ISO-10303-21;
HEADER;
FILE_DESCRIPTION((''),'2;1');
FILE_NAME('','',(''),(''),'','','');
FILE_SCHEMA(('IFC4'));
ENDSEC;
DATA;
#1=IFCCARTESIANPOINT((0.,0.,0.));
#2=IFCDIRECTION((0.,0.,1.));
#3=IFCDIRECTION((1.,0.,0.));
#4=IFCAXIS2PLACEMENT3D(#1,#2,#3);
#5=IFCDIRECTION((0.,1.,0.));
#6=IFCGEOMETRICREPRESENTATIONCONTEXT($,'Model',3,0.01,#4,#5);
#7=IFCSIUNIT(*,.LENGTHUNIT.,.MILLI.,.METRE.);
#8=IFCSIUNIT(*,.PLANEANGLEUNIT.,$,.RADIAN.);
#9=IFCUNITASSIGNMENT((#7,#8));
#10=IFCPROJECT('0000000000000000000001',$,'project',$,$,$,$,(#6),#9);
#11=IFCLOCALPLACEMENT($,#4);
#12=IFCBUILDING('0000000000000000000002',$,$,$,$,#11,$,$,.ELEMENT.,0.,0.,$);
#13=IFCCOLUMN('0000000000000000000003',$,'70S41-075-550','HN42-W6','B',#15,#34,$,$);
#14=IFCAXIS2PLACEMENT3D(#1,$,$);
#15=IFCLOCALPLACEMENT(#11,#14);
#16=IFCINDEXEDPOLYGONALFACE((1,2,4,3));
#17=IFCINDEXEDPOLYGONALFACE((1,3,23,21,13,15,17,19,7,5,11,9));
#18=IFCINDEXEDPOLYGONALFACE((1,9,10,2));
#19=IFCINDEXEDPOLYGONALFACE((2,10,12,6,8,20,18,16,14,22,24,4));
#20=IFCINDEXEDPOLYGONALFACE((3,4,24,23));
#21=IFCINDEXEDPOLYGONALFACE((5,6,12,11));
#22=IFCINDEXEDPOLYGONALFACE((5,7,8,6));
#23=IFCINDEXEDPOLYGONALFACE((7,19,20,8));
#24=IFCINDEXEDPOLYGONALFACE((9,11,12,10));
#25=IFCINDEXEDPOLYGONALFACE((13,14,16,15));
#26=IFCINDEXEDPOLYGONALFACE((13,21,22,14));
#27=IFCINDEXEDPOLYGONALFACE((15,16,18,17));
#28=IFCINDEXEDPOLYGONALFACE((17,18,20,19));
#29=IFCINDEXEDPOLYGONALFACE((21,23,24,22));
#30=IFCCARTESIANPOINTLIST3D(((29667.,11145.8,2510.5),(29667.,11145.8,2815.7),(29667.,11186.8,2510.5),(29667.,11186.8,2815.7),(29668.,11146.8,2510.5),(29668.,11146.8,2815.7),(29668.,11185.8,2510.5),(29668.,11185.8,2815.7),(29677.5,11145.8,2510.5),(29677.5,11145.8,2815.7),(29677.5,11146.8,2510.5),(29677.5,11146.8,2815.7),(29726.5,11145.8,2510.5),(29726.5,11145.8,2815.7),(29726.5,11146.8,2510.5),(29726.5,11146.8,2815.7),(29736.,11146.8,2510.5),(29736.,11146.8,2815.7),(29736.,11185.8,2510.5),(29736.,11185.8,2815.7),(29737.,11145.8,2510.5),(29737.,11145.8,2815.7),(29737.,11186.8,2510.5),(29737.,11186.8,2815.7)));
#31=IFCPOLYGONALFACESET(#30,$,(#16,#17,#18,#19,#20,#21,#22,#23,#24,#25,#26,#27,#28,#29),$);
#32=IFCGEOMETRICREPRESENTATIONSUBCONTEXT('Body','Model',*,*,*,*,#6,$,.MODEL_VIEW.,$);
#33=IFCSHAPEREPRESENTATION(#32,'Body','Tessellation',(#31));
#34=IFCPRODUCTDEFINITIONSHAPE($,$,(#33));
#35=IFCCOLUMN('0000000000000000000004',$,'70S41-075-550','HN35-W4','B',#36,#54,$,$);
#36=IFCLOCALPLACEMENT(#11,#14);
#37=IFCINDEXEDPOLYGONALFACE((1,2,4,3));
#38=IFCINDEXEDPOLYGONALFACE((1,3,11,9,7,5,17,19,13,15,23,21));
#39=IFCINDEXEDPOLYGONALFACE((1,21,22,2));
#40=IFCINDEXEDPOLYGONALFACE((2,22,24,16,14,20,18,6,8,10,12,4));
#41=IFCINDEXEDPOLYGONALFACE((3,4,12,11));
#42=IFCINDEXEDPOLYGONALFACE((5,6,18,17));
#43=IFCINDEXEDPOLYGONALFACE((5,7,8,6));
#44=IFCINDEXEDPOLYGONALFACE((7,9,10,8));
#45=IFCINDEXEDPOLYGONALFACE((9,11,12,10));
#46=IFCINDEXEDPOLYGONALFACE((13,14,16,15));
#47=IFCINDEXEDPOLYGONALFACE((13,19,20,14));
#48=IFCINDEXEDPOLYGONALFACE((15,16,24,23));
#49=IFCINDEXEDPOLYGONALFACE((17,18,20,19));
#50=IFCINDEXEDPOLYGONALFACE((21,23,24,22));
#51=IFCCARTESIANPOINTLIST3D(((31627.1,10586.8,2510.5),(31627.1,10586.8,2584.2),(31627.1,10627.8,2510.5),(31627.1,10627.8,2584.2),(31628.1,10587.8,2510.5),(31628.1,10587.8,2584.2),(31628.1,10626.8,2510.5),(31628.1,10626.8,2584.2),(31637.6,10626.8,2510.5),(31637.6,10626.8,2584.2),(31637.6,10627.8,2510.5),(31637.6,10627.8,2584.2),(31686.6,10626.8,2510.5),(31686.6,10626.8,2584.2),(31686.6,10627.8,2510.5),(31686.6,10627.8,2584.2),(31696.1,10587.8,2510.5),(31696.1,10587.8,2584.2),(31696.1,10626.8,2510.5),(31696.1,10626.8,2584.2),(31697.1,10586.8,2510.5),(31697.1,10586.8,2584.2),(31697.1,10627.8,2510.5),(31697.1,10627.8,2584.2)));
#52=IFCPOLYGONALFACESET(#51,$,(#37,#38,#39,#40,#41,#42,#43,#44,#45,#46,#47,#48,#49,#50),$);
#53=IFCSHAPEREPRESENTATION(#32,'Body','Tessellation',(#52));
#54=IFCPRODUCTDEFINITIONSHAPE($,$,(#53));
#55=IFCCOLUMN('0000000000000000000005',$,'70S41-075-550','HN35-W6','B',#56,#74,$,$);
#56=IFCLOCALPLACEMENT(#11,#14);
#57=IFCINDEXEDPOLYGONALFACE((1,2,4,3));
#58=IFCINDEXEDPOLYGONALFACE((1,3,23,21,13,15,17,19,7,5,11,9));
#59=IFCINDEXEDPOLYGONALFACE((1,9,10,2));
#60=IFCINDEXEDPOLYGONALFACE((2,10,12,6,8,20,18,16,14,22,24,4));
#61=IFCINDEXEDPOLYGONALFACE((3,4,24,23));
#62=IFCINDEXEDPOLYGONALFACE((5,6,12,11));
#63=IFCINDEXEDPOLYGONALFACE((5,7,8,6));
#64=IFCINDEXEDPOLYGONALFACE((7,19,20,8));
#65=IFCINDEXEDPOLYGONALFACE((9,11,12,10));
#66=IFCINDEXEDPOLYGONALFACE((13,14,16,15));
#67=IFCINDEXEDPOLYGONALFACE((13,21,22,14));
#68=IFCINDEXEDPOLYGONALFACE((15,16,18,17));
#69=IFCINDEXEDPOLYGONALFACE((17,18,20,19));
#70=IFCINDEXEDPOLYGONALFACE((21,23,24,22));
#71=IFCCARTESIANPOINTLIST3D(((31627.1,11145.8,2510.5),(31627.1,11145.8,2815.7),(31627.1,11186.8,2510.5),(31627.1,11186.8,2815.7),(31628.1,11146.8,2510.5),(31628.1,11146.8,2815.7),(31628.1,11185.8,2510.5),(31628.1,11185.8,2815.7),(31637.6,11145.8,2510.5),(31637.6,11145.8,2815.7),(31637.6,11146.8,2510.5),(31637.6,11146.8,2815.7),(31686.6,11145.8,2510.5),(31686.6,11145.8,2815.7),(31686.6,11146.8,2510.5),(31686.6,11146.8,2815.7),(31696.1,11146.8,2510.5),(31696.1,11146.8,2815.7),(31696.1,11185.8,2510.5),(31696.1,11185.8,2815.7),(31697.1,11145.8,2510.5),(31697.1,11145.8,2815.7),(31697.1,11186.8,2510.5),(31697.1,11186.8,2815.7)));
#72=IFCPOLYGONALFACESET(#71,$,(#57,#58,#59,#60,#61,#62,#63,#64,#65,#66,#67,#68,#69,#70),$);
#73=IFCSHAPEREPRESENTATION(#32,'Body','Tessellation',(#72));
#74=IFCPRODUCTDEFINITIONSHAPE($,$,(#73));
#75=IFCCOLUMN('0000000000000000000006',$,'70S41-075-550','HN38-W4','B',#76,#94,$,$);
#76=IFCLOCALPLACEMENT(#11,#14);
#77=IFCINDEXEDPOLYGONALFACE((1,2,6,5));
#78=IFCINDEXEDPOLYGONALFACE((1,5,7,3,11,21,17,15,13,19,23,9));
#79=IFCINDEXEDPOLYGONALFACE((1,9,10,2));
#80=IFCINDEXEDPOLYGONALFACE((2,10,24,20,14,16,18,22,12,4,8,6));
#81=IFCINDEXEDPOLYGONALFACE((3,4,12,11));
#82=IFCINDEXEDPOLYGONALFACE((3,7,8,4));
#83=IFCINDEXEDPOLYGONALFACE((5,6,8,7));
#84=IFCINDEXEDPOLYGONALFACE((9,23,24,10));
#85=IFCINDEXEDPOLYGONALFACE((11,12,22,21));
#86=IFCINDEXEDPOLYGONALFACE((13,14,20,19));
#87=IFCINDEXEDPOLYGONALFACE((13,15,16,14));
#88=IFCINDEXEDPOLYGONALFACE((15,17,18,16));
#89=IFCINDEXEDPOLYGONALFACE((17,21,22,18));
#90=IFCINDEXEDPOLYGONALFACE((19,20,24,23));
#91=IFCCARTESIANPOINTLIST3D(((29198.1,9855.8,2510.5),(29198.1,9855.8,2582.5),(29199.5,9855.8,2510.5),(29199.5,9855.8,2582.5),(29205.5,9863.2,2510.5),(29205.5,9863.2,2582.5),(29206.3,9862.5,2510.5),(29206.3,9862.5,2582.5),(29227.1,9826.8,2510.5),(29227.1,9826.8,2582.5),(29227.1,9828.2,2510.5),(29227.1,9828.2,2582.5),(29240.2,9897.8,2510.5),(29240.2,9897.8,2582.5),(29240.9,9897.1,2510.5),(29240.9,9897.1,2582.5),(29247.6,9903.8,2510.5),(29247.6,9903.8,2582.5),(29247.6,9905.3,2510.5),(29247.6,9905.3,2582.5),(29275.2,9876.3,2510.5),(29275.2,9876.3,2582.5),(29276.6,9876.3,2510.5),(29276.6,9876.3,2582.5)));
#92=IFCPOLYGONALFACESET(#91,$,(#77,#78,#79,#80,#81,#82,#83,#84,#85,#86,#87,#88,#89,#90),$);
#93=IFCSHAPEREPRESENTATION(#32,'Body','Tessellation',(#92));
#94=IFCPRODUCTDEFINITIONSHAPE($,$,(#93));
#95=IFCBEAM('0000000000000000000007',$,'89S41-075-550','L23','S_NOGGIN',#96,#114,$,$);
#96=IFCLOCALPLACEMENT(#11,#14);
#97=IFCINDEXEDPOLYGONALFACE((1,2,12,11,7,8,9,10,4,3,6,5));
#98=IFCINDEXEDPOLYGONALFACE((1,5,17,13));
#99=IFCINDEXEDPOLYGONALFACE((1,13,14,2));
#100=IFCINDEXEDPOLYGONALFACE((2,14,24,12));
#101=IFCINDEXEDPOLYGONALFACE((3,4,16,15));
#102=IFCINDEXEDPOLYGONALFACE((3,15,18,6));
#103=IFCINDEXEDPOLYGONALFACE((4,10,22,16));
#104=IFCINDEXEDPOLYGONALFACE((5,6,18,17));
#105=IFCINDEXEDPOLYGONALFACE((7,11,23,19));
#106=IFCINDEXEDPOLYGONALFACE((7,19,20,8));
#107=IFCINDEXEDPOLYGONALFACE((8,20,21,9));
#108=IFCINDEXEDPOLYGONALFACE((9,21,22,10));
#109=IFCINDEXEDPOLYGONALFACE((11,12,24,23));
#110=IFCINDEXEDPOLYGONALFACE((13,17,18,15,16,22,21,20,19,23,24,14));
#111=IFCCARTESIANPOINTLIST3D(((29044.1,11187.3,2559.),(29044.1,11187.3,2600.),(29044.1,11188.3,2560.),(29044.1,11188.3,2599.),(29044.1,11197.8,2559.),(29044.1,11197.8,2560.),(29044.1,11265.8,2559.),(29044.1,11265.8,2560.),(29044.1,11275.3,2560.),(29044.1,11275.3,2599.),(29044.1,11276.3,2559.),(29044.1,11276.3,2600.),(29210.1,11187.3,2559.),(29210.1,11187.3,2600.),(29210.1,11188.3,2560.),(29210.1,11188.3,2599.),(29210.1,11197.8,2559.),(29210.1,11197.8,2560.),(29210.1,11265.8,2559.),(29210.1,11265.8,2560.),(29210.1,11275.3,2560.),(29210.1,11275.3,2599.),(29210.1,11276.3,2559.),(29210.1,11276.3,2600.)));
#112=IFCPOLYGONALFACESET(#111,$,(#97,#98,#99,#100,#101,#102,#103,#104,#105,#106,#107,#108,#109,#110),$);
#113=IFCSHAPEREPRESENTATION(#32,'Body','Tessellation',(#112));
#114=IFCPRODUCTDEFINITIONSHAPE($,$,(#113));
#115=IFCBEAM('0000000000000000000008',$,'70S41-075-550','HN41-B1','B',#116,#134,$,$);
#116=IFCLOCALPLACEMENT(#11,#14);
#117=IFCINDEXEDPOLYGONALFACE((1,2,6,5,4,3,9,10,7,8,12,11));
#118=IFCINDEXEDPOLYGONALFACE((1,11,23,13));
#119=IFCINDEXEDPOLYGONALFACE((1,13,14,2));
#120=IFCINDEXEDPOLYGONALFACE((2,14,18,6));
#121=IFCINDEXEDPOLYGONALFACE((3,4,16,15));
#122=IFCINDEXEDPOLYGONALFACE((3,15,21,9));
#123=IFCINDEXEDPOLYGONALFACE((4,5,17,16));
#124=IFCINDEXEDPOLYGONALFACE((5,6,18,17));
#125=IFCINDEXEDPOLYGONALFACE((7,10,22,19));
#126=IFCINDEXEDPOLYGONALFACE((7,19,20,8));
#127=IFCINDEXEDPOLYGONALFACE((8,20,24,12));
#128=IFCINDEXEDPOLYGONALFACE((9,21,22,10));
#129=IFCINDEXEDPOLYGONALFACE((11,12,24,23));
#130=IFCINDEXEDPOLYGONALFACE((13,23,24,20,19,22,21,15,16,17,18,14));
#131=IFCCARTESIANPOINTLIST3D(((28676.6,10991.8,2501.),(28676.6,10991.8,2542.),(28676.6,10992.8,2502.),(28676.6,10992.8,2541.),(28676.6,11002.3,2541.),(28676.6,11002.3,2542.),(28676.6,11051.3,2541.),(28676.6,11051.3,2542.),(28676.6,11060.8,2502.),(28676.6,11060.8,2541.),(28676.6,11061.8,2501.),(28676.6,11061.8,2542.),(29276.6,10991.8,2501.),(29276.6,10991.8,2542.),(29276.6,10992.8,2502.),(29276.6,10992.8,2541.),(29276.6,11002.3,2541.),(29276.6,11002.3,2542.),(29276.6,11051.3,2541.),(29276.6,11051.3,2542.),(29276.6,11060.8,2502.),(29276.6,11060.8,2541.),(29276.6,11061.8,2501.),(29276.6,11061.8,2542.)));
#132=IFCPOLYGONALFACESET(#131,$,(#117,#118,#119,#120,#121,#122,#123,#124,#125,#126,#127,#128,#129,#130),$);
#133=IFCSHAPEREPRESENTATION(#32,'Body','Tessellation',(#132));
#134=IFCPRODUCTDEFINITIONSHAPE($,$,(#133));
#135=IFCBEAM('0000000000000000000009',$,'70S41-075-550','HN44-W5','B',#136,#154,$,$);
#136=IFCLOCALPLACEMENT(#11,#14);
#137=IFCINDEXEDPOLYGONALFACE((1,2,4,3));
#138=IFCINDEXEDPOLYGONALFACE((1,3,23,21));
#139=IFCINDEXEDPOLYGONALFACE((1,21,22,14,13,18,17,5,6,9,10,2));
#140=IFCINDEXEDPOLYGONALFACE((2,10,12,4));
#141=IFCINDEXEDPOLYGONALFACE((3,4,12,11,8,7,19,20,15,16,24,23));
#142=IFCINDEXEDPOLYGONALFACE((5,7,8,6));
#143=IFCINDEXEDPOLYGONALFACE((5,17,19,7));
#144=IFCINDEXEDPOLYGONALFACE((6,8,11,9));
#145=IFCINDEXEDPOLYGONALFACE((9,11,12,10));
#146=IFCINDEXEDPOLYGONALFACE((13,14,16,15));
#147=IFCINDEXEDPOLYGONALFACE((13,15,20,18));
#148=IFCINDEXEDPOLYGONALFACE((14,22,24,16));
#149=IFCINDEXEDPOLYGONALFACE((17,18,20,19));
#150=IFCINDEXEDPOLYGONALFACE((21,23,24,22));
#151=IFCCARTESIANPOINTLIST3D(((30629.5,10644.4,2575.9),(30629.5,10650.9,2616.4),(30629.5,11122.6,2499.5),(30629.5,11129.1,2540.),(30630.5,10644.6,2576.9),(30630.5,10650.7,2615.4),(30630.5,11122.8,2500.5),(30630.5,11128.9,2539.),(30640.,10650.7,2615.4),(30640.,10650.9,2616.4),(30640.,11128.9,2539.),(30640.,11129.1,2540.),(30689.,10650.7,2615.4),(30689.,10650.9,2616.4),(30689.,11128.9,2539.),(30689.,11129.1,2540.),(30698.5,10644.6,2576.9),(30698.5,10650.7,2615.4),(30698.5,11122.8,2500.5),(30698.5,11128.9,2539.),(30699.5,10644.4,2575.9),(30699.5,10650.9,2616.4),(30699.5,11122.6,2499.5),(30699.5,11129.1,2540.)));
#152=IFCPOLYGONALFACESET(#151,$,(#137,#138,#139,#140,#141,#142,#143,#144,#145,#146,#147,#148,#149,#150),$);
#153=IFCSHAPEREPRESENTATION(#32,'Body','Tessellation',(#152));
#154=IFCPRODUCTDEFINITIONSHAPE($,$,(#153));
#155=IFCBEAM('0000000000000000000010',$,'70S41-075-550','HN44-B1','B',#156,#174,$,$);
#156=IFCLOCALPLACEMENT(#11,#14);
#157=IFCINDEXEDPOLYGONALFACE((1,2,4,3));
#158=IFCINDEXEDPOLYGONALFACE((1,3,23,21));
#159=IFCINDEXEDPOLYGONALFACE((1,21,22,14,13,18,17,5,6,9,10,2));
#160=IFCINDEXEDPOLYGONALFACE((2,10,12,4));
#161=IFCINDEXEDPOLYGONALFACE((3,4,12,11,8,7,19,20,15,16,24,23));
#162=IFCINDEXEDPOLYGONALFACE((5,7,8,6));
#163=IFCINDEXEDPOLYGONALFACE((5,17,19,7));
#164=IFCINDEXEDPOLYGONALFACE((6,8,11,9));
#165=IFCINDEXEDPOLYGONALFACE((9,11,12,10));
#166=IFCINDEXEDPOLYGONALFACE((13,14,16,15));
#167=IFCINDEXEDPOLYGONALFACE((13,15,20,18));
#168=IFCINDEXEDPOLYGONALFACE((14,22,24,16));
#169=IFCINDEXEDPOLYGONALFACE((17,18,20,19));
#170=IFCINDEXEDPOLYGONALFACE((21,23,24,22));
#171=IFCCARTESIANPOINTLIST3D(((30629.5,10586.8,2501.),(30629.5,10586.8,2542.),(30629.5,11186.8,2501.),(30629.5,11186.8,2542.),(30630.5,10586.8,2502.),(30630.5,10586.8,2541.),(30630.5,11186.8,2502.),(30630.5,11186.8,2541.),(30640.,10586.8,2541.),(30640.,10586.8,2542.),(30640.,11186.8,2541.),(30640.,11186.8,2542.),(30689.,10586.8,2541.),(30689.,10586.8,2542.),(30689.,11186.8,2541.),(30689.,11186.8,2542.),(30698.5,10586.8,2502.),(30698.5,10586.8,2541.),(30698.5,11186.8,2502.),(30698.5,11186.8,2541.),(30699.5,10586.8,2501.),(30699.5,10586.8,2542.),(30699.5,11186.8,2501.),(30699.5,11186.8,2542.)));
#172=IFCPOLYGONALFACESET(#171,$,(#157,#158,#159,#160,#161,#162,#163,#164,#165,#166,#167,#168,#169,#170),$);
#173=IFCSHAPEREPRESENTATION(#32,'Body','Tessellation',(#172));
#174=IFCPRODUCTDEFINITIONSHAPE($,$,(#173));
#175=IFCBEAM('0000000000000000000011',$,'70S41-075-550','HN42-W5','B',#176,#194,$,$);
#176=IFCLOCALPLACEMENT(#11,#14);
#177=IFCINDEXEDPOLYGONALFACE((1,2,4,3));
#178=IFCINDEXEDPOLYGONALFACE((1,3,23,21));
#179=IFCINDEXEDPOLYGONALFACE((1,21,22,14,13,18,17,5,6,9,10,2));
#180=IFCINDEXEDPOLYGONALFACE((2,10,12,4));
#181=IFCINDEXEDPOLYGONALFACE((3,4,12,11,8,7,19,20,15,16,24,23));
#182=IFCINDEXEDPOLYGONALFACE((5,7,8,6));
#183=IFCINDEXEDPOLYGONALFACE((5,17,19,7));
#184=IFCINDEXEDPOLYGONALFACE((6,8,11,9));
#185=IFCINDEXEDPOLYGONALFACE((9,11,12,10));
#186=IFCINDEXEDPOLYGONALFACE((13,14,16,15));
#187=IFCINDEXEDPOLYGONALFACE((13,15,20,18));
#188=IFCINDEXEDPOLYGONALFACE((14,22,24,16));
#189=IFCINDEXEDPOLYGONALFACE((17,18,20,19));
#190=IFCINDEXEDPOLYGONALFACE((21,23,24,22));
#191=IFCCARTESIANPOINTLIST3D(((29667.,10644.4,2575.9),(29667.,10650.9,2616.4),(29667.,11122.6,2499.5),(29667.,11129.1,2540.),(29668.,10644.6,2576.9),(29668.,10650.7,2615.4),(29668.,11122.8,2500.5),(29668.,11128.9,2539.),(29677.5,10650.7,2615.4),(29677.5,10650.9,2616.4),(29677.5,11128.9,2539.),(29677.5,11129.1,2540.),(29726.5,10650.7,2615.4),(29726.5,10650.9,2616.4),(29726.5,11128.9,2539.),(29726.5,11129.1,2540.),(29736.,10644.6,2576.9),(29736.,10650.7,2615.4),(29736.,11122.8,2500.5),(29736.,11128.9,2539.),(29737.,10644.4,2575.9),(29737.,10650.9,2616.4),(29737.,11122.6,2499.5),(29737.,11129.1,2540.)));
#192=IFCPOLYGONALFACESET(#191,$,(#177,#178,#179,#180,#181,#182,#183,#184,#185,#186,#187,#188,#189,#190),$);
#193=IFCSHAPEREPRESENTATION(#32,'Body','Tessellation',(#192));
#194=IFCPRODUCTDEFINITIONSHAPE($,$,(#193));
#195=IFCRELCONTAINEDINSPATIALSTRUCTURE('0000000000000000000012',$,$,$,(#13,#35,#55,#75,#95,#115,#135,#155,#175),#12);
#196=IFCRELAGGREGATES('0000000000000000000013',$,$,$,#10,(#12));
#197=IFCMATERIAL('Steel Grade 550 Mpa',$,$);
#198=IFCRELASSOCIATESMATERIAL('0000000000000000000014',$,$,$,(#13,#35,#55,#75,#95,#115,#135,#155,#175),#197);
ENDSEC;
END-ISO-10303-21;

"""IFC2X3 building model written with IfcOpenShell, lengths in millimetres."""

from ifc_helpers import new_model, si_unit, direction, frame, origin, origin_with_axes, origin_2d_with_axis, place, context, subcontext, project, spatial, c_section, extrude, source, transform, mapped, material, element, save


model = new_model("IFC2X3")

# Units and contexts
model_context = context("Model", 3, precision=0.01, world=origin_with_axes(), true_north=direction((0.0, 1.0, 0.0)))
body_context = subcontext(model_context, "Body", "Model", "MODEL_VIEW")
ifc_project = project(units=[si_unit("LENGTHUNIT", "METRE", prefix="MILLI"), si_unit("PLANEANGLEUNIT", "RADIAN")], contexts=[model_context])

# Building
building_placement = place(None, origin_with_axes())
building = spatial("IfcBuilding", under=ifc_project, at=building_placement, CompositionType="ELEMENT", ElevationOfRefHeight=0.0, ElevationOfTerrain=0.0)

# Columns
ifc_material = material(Name="Steel Grade 550 Mpa")
shared_shape_1 = source(origin(), body_context, "Body", "SweptSolid", [
    extrude(c_section(Depth=70.0, Width=41.0, WallThickness=1.0, Girth=10.5, at=origin_2d_with_axis()), origin_with_axes(), (0.0, 0.0, 1.0), 305.2),
])
column_1_placement = place(None, frame((29702.0, 11166.3, 2510.5), z_axis=(0.0, 0.0, 1.0), x_axis=(0.0, -1.0, 0.0)))
element("IfcColumn", 1, at=column_1_placement, inside=building, material=ifc_material, Name="70S41-075-550", Description="HN42-W6", ObjectType="B", context=body_context, shape_type="MappedRepresentation", body=[
    mapped(shared_shape_1, transform((0.0, 0.0, 0.0), scale=1.0)),
])
shared_shape_2 = source(origin(), body_context, "Body", "SweptSolid", [
    extrude(c_section(Depth=70.0, Width=41.0, WallThickness=1.0, Girth=10.5, at=origin_2d_with_axis()), origin_with_axes(), (0.0, 0.0, 1.0), 73.7),
])
column_2_placement = place(None, frame((31662.1, 10607.3, 2584.2), z_axis=(0.0, 0.0, -1.0), x_axis=(0.0, 1.0, 0.0)))
element("IfcColumn", 2, at=column_2_placement, inside=building, material=ifc_material, Name="70S41-075-550", Description="HN35-W4", ObjectType="B", context=body_context, shape_type="MappedRepresentation", body=[
    mapped(shared_shape_2, transform((0.0, 0.0, 0.0), scale=1.0)),
])
shared_shape_3 = source(origin(), body_context, "Body", "SweptSolid", [
    extrude(c_section(Depth=70.0, Width=41.0, WallThickness=1.0, Girth=10.5, at=origin_2d_with_axis()), origin_with_axes(), (0.0, 0.0, 1.0), 305.2),
])
column_3_placement = place(None, frame((31662.1, 11166.3, 2510.5), z_axis=(0.0, 0.0, 1.0), x_axis=(0.0, -1.0, 0.0)))
element("IfcColumn", 3, at=column_3_placement, inside=building, material=ifc_material, Name="70S41-075-550", Description="HN35-W6", ObjectType="B", context=body_context, shape_type="MappedRepresentation", body=[
    mapped(shared_shape_3, transform((0.0, 0.0, 0.0), scale=1.0)),
])
shared_shape_4 = source(origin(), body_context, "Body", "SweptSolid", [
    extrude(c_section(Depth=70.0, Width=41.0, WallThickness=1.0, Girth=10.5, at=origin_2d_with_axis()), origin_with_axes(), (0.0, 0.0, 1.0), 72.0),
])
column_4_placement = place(None, frame((29237.4, 9866.0, 2582.5), z_axis=(0.0, 0.0, -1.0), x_axis=(-0.707107, 0.707107, 0.0)))
element("IfcColumn", 4, at=column_4_placement, inside=building, material=ifc_material, Name="70S41-075-550", Description="HN38-W4", ObjectType="B", context=body_context, shape_type="MappedRepresentation", body=[
    mapped(shared_shape_4, transform((0.0, 0.0, 0.0), scale=1.0)),
])

# Beams
shared_shape_5 = source(origin(), body_context, "Body", "SweptSolid", [
    extrude(c_section(Depth=89.0, Width=41.0, WallThickness=1.0, Girth=10.5, at=origin_2d_with_axis()), origin_with_axes(), (0.0, 0.0, 1.0), 166.0),
])
beam_1_placement = place(None, frame((29044.1, 11231.8, 2579.5), z_axis=(1.0, 0.0, 0.0), x_axis=(0.0, 0.0, -1.0)))
element("IfcBeam", 5, at=beam_1_placement, inside=building, material=ifc_material, Name="89S41-075-550", Description="L23", ObjectType="S_NOGGIN", context=body_context, shape_type="MappedRepresentation", body=[
    mapped(shared_shape_5, transform((0.0, 0.0, 0.0), scale=1.0)),
])
shared_shape_6 = source(origin(), body_context, "Body", "SweptSolid", [
    extrude(c_section(Depth=70.0, Width=41.0, WallThickness=1.0, Girth=10.5, at=origin_2d_with_axis()), origin_with_axes(), (0.0, 0.0, 1.0), 600.0),
])
beam_2_placement = place(None, frame((29276.6, 11026.8, 2521.5), z_axis=(-1.0, 0.0, 0.0), x_axis=(0.0, 0.0, 1.0)))
element("IfcBeam", 6, at=beam_2_placement, inside=building, material=ifc_material, Name="70S41-075-550", Description="HN41-B1", ObjectType="B", context=body_context, shape_type="MappedRepresentation", body=[
    mapped(shared_shape_6, transform((0.0, 0.0, 0.0), scale=1.0)),
])
shared_shape_7 = source(origin(), body_context, "Body", "SweptSolid", [
    extrude(c_section(Depth=70.0, Width=41.0, WallThickness=1.0, Girth=10.5, at=origin_2d_with_axis()), origin_with_axes(), (0.0, 0.0, 1.0), 484.3),
])
beam_3_placement = place(None, frame((30664.5, 10647.6, 2596.1), z_axis=(0.0, 0.987487, -0.157701), x_axis=(0.0, 0.157701, 0.987487)))
element("IfcBeam", 7, at=beam_3_placement, inside=building, material=ifc_material, Name="70S41-075-550", Description="HN44-W5", ObjectType="B", context=body_context, shape_type="MappedRepresentation", body=[
    mapped(shared_shape_7, transform((0.0, 0.0, 0.0), scale=1.0)),
])
shared_shape_8 = source(origin(), body_context, "Body", "SweptSolid", [
    extrude(c_section(Depth=70.0, Width=41.0, WallThickness=1.0, Girth=10.5, at=origin_2d_with_axis()), origin_with_axes(), (0.0, 0.0, 1.0), 600.0),
])
beam_4_placement = place(None, frame((30664.5, 10586.8, 2521.5), z_axis=(0.0, 1.0, 0.0), x_axis=(0.0, 0.0, 1.0)))
element("IfcBeam", 8, at=beam_4_placement, inside=building, material=ifc_material, Name="70S41-075-550", Description="HN44-B1", ObjectType="B", context=body_context, shape_type="MappedRepresentation", body=[
    mapped(shared_shape_8, transform((0.0, 0.0, 0.0), scale=1.0)),
])
shared_shape_9 = source(origin(), body_context, "Body", "SweptSolid", [
    extrude(c_section(Depth=70.0, Width=41.0, WallThickness=1.0, Girth=10.5, at=origin_2d_with_axis()), origin_with_axes(), (0.0, 0.0, 1.0), 484.3),
])
beam_5_placement = place(None, frame((29702.0, 10647.6, 2596.1), z_axis=(0.0, 0.987487, -0.157701), x_axis=(0.0, 0.157701, 0.987487)))
element("IfcBeam", 9, at=beam_5_placement, inside=building, material=ifc_material, Name="70S41-075-550", Description="HN42-W5", ObjectType="B", context=body_context, shape_type="MappedRepresentation", body=[
    mapped(shared_shape_9, transform((0.0, 0.0, 0.0), scale=1.0)),
])

save(model, "model.ifc")
